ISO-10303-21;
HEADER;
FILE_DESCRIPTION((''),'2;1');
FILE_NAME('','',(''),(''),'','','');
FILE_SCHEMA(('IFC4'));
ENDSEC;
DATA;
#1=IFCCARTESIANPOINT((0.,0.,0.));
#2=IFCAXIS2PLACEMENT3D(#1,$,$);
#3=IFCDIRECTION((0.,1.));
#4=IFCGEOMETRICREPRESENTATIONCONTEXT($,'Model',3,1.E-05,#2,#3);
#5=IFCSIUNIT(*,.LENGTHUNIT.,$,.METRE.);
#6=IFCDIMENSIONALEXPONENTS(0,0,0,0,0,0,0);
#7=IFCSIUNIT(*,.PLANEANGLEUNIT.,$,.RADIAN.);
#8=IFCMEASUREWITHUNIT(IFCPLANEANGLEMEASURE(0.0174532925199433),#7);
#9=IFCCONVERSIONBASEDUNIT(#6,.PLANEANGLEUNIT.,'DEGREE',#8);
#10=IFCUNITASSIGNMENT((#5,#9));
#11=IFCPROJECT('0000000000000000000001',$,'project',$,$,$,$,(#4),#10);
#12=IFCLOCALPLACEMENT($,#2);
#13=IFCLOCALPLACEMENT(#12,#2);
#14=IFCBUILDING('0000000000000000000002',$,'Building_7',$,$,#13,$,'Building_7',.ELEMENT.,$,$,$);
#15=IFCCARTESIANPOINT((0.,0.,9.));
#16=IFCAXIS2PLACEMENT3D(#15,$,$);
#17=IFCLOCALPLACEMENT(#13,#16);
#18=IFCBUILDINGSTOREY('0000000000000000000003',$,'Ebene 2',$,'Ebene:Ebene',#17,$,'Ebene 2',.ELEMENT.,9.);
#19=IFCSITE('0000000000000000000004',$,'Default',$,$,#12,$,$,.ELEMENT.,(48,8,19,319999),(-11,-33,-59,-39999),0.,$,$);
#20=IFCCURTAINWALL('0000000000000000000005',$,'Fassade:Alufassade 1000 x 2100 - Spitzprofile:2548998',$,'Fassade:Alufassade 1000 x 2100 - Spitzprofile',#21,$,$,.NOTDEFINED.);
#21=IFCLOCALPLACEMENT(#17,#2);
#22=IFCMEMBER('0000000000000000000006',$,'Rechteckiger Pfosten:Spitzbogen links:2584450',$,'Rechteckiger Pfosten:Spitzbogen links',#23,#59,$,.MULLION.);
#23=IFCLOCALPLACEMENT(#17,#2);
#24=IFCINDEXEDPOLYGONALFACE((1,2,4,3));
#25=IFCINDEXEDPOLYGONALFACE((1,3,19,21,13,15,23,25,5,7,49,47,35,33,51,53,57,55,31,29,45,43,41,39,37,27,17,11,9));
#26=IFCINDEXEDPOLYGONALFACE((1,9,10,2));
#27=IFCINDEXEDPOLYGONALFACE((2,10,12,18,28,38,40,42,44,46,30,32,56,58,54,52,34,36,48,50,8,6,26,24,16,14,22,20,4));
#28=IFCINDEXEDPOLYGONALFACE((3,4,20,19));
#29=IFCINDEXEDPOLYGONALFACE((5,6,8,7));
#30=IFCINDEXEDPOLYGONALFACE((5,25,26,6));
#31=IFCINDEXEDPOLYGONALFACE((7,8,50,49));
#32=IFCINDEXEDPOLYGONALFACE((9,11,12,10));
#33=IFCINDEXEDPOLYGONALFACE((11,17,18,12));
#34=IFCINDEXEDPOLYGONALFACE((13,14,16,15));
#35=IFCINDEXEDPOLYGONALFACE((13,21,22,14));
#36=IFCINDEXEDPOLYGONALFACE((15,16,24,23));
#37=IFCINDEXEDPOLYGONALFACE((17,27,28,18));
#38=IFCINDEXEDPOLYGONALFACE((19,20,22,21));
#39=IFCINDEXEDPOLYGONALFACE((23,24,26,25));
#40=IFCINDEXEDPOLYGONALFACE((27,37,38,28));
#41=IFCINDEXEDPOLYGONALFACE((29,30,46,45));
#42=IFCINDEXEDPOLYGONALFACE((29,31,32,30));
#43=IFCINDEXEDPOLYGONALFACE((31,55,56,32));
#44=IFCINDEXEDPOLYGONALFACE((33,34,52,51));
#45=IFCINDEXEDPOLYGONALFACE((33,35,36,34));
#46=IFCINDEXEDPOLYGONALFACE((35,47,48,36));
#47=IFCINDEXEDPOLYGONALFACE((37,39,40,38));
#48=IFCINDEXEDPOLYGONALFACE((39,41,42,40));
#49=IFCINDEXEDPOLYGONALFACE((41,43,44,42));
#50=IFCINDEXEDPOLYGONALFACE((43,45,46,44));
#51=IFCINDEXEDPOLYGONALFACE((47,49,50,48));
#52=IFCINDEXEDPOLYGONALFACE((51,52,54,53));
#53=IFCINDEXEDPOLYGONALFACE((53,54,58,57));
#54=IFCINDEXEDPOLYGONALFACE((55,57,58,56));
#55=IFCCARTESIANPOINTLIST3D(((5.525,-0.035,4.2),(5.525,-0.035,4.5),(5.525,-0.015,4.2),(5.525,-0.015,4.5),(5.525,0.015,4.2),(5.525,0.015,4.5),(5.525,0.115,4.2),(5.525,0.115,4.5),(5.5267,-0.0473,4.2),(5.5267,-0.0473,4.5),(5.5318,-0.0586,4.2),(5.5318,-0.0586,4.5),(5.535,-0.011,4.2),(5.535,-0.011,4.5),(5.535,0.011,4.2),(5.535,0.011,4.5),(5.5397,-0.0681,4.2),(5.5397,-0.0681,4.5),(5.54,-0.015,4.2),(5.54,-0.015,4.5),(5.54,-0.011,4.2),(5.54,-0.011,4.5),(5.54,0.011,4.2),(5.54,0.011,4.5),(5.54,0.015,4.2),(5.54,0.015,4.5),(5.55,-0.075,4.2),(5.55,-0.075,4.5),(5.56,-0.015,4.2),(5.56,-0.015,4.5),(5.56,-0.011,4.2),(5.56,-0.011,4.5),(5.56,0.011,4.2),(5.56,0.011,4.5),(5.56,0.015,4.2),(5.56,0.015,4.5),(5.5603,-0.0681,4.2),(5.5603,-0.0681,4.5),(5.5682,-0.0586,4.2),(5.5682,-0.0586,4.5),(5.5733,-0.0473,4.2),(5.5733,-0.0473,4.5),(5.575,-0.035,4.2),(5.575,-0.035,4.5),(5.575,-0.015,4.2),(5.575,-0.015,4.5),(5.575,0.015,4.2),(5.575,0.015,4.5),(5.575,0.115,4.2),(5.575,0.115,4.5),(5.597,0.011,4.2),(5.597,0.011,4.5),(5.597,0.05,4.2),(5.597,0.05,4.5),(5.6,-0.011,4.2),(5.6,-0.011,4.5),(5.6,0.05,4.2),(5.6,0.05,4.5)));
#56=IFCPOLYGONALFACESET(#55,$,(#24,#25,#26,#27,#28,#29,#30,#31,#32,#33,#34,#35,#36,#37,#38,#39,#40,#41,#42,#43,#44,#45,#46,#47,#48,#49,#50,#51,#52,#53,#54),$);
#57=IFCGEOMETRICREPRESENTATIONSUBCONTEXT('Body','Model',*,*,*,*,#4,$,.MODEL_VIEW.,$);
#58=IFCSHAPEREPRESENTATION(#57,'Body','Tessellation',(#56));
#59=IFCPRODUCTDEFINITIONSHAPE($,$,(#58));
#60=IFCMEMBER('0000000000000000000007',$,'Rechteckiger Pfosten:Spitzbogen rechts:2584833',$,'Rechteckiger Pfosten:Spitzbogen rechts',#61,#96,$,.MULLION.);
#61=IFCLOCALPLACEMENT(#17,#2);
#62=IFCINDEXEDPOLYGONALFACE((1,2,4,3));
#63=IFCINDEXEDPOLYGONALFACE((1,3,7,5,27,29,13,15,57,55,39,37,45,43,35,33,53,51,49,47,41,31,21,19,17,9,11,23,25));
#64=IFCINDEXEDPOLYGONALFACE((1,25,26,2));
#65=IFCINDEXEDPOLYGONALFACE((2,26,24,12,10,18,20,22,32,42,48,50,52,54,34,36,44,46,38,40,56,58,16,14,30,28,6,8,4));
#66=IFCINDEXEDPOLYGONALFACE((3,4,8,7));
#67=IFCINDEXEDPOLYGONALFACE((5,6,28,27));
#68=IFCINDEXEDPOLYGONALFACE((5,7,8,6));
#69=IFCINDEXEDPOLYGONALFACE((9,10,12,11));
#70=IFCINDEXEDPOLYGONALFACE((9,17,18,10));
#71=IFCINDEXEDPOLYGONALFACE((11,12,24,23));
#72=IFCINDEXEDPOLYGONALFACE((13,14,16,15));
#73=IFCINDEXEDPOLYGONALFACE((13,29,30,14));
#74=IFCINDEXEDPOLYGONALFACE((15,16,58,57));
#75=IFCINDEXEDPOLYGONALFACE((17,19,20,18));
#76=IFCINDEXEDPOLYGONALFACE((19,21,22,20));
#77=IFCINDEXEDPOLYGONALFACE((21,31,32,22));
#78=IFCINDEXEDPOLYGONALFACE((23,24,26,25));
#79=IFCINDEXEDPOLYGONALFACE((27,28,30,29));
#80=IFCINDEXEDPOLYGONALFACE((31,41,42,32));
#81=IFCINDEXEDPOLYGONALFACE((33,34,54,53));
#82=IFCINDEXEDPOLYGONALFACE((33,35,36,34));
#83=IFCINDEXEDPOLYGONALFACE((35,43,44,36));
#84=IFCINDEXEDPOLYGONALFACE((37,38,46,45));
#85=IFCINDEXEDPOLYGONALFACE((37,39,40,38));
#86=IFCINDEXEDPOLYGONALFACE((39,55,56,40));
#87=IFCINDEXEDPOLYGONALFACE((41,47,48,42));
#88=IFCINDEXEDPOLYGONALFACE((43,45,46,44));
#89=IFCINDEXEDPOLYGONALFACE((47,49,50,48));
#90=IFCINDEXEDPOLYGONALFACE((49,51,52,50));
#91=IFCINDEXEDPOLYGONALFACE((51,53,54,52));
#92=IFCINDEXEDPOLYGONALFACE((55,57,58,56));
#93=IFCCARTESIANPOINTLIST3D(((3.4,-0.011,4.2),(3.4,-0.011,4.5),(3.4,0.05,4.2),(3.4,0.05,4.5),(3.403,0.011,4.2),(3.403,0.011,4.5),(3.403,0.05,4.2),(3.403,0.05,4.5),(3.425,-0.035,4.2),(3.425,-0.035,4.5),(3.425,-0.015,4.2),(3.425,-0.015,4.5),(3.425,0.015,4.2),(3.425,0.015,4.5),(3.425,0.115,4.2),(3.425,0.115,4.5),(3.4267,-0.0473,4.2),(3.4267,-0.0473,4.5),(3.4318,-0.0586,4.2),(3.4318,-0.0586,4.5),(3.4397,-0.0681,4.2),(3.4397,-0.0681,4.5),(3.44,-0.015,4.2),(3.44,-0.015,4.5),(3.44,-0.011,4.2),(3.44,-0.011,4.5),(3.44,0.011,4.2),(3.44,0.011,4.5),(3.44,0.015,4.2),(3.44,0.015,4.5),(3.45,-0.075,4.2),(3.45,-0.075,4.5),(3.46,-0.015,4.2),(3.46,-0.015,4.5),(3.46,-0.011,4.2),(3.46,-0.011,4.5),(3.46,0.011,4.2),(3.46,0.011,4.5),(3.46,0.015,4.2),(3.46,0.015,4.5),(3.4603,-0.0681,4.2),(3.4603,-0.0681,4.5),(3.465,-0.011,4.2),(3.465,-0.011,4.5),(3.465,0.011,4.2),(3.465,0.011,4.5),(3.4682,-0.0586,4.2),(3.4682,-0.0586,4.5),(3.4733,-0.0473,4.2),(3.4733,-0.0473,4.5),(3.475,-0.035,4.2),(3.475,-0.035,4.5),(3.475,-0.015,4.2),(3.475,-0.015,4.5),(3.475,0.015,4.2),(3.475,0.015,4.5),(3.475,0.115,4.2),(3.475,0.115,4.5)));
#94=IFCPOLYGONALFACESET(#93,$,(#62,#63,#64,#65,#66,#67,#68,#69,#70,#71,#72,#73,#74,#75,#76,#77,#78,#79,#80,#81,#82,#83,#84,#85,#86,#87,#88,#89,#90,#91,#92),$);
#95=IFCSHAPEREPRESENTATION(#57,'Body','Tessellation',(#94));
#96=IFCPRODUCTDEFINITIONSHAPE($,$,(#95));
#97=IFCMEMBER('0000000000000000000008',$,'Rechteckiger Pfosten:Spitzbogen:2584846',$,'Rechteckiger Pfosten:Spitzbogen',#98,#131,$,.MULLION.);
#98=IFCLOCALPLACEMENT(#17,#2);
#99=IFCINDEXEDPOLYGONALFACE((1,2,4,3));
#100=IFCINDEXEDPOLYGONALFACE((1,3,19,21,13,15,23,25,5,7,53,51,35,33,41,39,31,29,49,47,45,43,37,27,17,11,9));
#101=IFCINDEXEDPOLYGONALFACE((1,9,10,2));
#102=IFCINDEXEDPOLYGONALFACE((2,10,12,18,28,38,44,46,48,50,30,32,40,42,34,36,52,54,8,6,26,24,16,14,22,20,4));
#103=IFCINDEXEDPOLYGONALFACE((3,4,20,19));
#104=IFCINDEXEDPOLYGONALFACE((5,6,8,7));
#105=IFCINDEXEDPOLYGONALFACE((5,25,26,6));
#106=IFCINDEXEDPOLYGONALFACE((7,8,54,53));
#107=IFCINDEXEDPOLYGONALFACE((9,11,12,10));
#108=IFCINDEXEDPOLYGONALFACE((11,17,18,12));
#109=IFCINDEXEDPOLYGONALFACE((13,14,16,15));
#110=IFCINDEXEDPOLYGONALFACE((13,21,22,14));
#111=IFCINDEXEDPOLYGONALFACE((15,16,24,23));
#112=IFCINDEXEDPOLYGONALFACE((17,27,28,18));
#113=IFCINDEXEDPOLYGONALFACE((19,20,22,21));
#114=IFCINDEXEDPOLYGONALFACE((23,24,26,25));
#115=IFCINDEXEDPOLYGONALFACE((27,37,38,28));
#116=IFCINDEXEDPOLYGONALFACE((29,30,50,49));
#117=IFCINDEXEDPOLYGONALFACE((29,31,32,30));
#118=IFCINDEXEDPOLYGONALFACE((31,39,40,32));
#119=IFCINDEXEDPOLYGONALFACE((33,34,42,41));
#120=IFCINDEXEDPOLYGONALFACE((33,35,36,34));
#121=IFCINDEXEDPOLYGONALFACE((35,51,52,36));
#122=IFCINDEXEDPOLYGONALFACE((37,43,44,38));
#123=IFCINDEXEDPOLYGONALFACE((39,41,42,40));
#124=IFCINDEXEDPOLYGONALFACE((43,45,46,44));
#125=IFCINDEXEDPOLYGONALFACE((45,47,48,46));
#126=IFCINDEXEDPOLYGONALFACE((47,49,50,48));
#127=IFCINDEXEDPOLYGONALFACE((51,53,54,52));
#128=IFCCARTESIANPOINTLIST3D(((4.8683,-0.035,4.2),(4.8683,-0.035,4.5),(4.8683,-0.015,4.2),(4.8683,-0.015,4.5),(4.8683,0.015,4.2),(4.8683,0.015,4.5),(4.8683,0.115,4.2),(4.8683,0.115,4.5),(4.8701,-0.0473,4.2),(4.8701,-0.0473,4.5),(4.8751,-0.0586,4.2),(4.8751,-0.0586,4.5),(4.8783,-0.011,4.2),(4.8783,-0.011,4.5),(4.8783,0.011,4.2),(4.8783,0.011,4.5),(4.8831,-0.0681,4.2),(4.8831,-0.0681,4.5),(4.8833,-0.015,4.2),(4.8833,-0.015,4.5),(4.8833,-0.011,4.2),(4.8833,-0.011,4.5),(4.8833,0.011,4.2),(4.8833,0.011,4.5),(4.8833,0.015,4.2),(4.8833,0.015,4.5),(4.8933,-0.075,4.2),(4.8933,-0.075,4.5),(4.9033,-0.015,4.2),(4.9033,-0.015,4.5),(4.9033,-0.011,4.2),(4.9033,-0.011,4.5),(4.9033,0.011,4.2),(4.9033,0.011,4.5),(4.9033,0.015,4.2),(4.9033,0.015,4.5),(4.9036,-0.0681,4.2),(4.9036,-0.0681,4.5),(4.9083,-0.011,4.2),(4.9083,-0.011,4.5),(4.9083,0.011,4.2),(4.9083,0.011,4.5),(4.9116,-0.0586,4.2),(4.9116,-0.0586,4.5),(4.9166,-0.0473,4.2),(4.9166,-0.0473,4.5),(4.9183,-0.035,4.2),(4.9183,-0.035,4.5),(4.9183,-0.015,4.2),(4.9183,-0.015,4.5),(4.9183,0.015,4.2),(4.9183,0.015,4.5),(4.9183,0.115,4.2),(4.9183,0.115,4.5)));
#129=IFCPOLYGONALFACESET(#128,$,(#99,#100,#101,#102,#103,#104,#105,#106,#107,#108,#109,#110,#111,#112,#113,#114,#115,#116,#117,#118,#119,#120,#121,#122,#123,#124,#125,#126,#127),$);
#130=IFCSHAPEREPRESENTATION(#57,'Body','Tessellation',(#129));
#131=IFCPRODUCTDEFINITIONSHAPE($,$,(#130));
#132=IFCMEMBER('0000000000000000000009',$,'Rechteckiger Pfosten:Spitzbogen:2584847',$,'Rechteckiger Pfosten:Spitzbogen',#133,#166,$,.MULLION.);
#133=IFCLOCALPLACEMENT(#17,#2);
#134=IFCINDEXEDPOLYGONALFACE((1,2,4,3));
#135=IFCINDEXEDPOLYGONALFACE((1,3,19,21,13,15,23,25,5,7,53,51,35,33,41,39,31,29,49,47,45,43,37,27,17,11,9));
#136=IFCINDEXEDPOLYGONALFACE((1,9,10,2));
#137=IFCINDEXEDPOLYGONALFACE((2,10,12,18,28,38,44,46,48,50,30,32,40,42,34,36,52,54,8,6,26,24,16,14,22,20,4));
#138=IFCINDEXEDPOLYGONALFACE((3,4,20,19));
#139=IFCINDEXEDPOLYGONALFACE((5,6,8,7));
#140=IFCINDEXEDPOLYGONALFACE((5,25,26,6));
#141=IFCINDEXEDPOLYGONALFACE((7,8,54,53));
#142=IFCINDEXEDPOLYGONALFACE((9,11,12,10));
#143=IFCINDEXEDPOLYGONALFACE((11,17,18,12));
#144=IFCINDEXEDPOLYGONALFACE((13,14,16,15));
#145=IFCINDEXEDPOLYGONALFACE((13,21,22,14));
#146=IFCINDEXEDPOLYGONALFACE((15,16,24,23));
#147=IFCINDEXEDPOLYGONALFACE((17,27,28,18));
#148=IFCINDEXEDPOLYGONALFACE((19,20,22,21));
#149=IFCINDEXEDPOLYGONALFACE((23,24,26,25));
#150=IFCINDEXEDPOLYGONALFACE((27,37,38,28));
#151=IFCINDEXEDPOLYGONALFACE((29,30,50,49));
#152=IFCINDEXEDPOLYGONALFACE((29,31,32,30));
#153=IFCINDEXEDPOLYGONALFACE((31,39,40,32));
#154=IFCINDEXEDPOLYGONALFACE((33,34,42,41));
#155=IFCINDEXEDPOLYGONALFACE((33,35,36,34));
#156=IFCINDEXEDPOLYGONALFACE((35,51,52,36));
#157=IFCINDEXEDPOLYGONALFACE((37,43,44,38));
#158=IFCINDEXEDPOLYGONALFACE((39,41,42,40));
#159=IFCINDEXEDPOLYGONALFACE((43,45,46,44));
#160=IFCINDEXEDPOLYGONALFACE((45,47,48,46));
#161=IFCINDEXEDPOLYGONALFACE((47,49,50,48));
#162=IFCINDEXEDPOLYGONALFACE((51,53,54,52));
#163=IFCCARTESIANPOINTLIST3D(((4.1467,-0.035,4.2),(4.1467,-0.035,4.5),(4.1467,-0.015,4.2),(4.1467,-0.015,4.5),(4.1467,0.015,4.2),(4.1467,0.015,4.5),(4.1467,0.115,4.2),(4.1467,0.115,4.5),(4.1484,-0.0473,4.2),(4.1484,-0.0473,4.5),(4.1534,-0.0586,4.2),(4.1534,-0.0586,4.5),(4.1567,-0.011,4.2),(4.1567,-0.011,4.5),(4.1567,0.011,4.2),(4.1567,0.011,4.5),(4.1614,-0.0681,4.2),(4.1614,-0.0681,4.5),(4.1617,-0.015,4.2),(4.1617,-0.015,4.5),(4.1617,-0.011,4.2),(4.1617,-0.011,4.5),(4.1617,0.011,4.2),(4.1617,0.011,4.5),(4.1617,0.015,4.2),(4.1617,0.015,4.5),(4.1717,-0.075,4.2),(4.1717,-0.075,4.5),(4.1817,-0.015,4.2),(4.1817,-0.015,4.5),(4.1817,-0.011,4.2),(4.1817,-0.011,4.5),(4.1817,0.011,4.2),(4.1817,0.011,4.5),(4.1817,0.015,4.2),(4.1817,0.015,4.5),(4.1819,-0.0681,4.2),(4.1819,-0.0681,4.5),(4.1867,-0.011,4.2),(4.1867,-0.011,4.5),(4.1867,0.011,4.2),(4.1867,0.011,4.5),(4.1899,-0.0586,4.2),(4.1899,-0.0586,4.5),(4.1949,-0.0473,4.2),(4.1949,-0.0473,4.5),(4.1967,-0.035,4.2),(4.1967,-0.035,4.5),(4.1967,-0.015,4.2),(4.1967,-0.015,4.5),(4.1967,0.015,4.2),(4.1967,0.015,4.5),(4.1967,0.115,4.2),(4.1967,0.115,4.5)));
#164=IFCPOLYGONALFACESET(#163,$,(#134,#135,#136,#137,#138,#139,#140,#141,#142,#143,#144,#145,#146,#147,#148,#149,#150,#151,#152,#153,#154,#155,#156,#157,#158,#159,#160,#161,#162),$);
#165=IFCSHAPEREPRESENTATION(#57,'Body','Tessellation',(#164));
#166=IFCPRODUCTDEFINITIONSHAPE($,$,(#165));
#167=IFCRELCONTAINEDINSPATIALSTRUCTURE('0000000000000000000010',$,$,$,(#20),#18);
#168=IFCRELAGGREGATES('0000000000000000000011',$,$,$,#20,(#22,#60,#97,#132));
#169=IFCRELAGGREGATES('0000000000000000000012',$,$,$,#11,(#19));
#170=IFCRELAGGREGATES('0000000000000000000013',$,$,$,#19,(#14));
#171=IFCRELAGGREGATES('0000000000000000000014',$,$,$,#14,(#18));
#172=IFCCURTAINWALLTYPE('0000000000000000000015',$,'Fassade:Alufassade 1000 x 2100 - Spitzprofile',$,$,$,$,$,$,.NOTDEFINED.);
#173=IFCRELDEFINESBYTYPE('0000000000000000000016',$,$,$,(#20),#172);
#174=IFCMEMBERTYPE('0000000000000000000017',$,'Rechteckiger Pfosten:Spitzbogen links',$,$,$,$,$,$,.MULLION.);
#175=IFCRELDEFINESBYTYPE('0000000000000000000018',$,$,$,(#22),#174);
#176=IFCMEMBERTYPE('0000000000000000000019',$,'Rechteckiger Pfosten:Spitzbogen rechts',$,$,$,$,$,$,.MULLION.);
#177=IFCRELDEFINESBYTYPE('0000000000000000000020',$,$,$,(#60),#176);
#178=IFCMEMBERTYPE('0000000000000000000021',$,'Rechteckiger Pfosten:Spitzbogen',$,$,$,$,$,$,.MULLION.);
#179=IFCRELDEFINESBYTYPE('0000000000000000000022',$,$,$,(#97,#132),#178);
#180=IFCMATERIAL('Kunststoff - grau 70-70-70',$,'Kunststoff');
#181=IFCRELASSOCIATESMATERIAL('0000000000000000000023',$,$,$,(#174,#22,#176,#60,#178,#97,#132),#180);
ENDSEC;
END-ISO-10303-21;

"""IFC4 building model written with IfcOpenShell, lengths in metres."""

from ifc_helpers import new_model, entity, si_unit, converted_unit, direction, frame, origin, place, context, subcontext, project, spatial, line, arc, indexed_curve, outline, extrude, source, transform, mapped, material, type_object, type_shapes, element, aggregate, save


model = new_model("IFC4")

# Units and contexts
model_context = context("Model", 3, precision=1e-05, world=origin(), true_north=direction((0.0, 1.0)))
body_context = subcontext(model_context, "Body", "Model", "MODEL_VIEW")
ifc_project = project(units=[si_unit("LENGTHUNIT", "METRE"), converted_unit("PLANEANGLEUNIT", "DEGREE", entity("IfcPlaneAngleMeasure", 0.0174532925199433), si_unit("PLANEANGLEUNIT", "RADIAN"), dimensions=[0, 0, 0, 0, 0, 0, 0])], contexts=[model_context])

# Site, building, storey
site_placement = place(None, origin())
site = spatial("IfcSite", under=ifc_project, at=site_placement, Name="Default", CompositionType="ELEMENT", RefLatitude=(48, 8, 19, 319999), RefLongitude=(-11, -33, -59, -39999), RefElevation=0.0)
building_placement = place(site_placement, origin())
building = spatial("IfcBuilding", under=site, at=building_placement, Name="Building_7", LongName="Building_7", CompositionType="ELEMENT")
storey_placement = place(building_placement, frame((0.0, 0.0, 9.0)))
storey = spatial("IfcBuildingStorey", under=building, at=storey_placement, Name="Ebene 2", ObjectType="Ebene:Ebene", LongName="Ebene 2", CompositionType="ELEMENT", Elevation=9.0)

# Curtain wall
curtain_wall_type = type_object("IfcCurtainWallType", Name="Fassade:Alufassade 1000 x 2100 - Spitzprofile", PredefinedType="NOTDEFINED")
curtain_wall_placement = place(storey_placement, frame((0.0, 0.0, -9.0)))
curtain_wall = element("IfcCurtainWall", 1, at=curtain_wall_placement, inside=storey, type_object=curtain_wall_type, Name="Fassade:Alufassade 1000 x 2100 - Spitzprofile:2548998", ObjectType="Fassade:Alufassade 1000 x 2100 - Spitzprofile", PredefinedType="NOTDEFINED")
ifc_material_1 = material(Name="Kunststoff - grau 70-70-70", Category="Kunststoff")

# Members
member_type_1 = type_object("IfcMemberType", Name="Rechteckiger Pfosten:Spitzbogen links", PredefinedType="MULLION", material=ifc_material_1)
shared_shape_1 = source(origin(), body_context, "Body", "SweptSolid", [
    extrude(outline(indexed_curve([(-0.107, -0.0321), (-0.007, -0.0321), (-0.007, -0.0171), (-0.003, -0.0171), (-0.003, -0.0221), (0.019, -0.0221), (0.019, -0.0171), (0.023, -0.0171), (0.023, -0.0321), (0.043, -0.0321), (0.0666, -0.0254), (0.083, -0.0071), (0.0666, 0.0111), (0.043, 0.0179), (0.023, 0.0179), (0.023, 0.0029), (0.019, 0.0029), (0.019, 0.0429), (-0.042, 0.0429), (-0.042, 0.0399), (-0.003, 0.0399), (-0.003, 0.0029), (-0.007, 0.0029), (-0.007, 0.0179), (-0.107, 0.0179)], segments=[line(1, 2, 3, 4, 5, 6, 7, 8, 9, 10), arc(10, 11, 12), arc(12, 13, 14), line(14, 15, 16, 17, 18, 19, 20, 21, 22, 23, 24, 25, 1)], self_intersect=False)), frame((-0.0429, 0.008, -0.3), z_axis=(0.0, 0.0, 1.0), x_axis=(0.0, -1.0, 0.0)), (0.0, 0.0, 1.0), 0.3),
])
type_shapes(member_type_1, [shared_shape_1])
member_1_placement = place(curtain_wall_placement, frame((5.6, 0.0, 13.5)))
member_1 = element("IfcMember", 2, at=member_1_placement, type_object=member_type_1, material=ifc_material_1, Name="Rechteckiger Pfosten:Spitzbogen links:2584450", ObjectType="Rechteckiger Pfosten:Spitzbogen links", PredefinedType="MULLION", context=body_context, shape_type="MappedRepresentation", body=[
    mapped(shared_shape_1, transform((0.0, 0.0, 0.0), scale=1.0)),
])
member_type_2 = type_object("IfcMemberType", Name="Rechteckiger Pfosten:Spitzbogen rechts", PredefinedType="MULLION", material=ifc_material_1)
shared_shape_2 = source(origin(), body_context, "Body", "SweptSolid", [
    extrude(outline(indexed_curve([(-0.107, -0.0321), (-0.007, -0.0321), (-0.007, -0.0171), (-0.003, -0.0171), (-0.003, -0.0221), (0.019, -0.0221), (0.019, -0.0171), (0.023, -0.0171), (0.023, -0.0321), (0.043, -0.0321), (0.0666, -0.0254), (0.083, -0.0071), (0.0666, 0.0111), (0.043, 0.0179), (0.023, 0.0179), (0.023, 0.0029), (0.019, 0.0029), (0.019, 0.0429), (-0.042, 0.0429), (-0.042, 0.0399), (-0.003, 0.0399), (-0.003, 0.0029), (-0.007, 0.0029), (-0.007, 0.0179), (-0.107, 0.0179)], segments=[line(1, 2, 3, 4, 5, 6, 7, 8, 9, 10), arc(10, 11, 12), arc(12, 13, 14), line(14, 15, 16, 17, 18, 19, 20, 21, 22, 23, 24, 25, 1)], self_intersect=False)), frame((-0.0429, 0.008, -0.3), z_axis=(0.0, 0.0, 1.0), x_axis=(0.0, -1.0, 0.0)), (0.0, 0.0, 1.0), 0.3),
])
type_shapes(member_type_2, [shared_shape_2])
member_2_placement = place(curtain_wall_placement, frame((3.4, 0.0, 13.2), z_axis=(0.0, 0.0, -1.0), x_axis=(-1.0, 0.0, 0.0)))
member_2 = element("IfcMember", 3, at=member_2_placement, type_object=member_type_2, material=ifc_material_1, Name="Rechteckiger Pfosten:Spitzbogen rechts:2584833", ObjectType="Rechteckiger Pfosten:Spitzbogen rechts", PredefinedType="MULLION", context=body_context, shape_type="MappedRepresentation", body=[
    mapped(shared_shape_2, transform((0.0, 0.0, 0.0), scale=1.0)),
])
member_type_3 = type_object("IfcMemberType", Name="Rechteckiger Pfosten:Spitzbogen", PredefinedType="MULLION", material=ifc_material_1)
shared_shape_3 = source(origin(), body_context, "Body", "SweptSolid", [
    extrude(outline(indexed_curve([(-0.111, -0.025), (-0.011, -0.025), (-0.011, -0.01), (-0.007, -0.01), (-0.007, -0.015), (0.015, -0.015), (0.015, -0.01), (0.019, -0.01), (0.019, -0.025), (0.039, -0.025), (0.0626, -0.0182), (0.079, 0.0), (0.0626, 0.0182), (0.039, 0.025), (0.019, 0.025), (0.019, 0.01), (0.015, 0.01), (0.015, 0.015), (-0.007, 0.015), (-0.007, 0.01), (-0.011, 0.01), (-0.011, 0.025), (-0.111, 0.025)], segments=[line(1, 2, 3, 4, 5, 6, 7, 8, 9, 10), arc(10, 11, 12), arc(12, 13, 14), line(14, 15, 16, 17, 18, 19, 20, 21, 22, 23, 1)], self_intersect=False)), frame((0.0, 0.004, -0.3), z_axis=(0.0, 0.0, 1.0), x_axis=(0.0, -1.0, 0.0)), (0.0, 0.0, 1.0), 0.3),
])
type_shapes(member_type_3, [shared_shape_3])
member_3_placement = place(curtain_wall_placement, frame((4.8933, 0.0, 13.2), z_axis=(0.0, 0.0, -1.0), x_axis=(-1.0, 0.0, 0.0)))
member_3 = element("IfcMember", 4, at=member_3_placement, type_object=member_type_3, material=ifc_material_1, Name="Rechteckiger Pfosten:Spitzbogen:2584846", ObjectType="Rechteckiger Pfosten:Spitzbogen", PredefinedType="MULLION", context=body_context, shape_type="MappedRepresentation", body=[
    mapped(shared_shape_3, transform((0.0, 0.0, 0.0), scale=1.0)),
])
member_4_placement = place(curtain_wall_placement, frame((4.1717, 0.0, 13.2), z_axis=(0.0, 0.0, -1.0), x_axis=(-1.0, 0.0, 0.0)))
member_4 = element("IfcMember", 5, at=member_4_placement, type_object=member_type_3, material=ifc_material_1, Name="Rechteckiger Pfosten:Spitzbogen:2584847", ObjectType="Rechteckiger Pfosten:Spitzbogen", PredefinedType="MULLION", context=body_context, shape_type="MappedRepresentation", body=[
    mapped(shared_shape_3, transform((0.0, 0.0, 0.0), scale=1.0)),
])

aggregate(curtain_wall, [member_1, member_2, member_3, member_4])

save(model, "model.ifc")
